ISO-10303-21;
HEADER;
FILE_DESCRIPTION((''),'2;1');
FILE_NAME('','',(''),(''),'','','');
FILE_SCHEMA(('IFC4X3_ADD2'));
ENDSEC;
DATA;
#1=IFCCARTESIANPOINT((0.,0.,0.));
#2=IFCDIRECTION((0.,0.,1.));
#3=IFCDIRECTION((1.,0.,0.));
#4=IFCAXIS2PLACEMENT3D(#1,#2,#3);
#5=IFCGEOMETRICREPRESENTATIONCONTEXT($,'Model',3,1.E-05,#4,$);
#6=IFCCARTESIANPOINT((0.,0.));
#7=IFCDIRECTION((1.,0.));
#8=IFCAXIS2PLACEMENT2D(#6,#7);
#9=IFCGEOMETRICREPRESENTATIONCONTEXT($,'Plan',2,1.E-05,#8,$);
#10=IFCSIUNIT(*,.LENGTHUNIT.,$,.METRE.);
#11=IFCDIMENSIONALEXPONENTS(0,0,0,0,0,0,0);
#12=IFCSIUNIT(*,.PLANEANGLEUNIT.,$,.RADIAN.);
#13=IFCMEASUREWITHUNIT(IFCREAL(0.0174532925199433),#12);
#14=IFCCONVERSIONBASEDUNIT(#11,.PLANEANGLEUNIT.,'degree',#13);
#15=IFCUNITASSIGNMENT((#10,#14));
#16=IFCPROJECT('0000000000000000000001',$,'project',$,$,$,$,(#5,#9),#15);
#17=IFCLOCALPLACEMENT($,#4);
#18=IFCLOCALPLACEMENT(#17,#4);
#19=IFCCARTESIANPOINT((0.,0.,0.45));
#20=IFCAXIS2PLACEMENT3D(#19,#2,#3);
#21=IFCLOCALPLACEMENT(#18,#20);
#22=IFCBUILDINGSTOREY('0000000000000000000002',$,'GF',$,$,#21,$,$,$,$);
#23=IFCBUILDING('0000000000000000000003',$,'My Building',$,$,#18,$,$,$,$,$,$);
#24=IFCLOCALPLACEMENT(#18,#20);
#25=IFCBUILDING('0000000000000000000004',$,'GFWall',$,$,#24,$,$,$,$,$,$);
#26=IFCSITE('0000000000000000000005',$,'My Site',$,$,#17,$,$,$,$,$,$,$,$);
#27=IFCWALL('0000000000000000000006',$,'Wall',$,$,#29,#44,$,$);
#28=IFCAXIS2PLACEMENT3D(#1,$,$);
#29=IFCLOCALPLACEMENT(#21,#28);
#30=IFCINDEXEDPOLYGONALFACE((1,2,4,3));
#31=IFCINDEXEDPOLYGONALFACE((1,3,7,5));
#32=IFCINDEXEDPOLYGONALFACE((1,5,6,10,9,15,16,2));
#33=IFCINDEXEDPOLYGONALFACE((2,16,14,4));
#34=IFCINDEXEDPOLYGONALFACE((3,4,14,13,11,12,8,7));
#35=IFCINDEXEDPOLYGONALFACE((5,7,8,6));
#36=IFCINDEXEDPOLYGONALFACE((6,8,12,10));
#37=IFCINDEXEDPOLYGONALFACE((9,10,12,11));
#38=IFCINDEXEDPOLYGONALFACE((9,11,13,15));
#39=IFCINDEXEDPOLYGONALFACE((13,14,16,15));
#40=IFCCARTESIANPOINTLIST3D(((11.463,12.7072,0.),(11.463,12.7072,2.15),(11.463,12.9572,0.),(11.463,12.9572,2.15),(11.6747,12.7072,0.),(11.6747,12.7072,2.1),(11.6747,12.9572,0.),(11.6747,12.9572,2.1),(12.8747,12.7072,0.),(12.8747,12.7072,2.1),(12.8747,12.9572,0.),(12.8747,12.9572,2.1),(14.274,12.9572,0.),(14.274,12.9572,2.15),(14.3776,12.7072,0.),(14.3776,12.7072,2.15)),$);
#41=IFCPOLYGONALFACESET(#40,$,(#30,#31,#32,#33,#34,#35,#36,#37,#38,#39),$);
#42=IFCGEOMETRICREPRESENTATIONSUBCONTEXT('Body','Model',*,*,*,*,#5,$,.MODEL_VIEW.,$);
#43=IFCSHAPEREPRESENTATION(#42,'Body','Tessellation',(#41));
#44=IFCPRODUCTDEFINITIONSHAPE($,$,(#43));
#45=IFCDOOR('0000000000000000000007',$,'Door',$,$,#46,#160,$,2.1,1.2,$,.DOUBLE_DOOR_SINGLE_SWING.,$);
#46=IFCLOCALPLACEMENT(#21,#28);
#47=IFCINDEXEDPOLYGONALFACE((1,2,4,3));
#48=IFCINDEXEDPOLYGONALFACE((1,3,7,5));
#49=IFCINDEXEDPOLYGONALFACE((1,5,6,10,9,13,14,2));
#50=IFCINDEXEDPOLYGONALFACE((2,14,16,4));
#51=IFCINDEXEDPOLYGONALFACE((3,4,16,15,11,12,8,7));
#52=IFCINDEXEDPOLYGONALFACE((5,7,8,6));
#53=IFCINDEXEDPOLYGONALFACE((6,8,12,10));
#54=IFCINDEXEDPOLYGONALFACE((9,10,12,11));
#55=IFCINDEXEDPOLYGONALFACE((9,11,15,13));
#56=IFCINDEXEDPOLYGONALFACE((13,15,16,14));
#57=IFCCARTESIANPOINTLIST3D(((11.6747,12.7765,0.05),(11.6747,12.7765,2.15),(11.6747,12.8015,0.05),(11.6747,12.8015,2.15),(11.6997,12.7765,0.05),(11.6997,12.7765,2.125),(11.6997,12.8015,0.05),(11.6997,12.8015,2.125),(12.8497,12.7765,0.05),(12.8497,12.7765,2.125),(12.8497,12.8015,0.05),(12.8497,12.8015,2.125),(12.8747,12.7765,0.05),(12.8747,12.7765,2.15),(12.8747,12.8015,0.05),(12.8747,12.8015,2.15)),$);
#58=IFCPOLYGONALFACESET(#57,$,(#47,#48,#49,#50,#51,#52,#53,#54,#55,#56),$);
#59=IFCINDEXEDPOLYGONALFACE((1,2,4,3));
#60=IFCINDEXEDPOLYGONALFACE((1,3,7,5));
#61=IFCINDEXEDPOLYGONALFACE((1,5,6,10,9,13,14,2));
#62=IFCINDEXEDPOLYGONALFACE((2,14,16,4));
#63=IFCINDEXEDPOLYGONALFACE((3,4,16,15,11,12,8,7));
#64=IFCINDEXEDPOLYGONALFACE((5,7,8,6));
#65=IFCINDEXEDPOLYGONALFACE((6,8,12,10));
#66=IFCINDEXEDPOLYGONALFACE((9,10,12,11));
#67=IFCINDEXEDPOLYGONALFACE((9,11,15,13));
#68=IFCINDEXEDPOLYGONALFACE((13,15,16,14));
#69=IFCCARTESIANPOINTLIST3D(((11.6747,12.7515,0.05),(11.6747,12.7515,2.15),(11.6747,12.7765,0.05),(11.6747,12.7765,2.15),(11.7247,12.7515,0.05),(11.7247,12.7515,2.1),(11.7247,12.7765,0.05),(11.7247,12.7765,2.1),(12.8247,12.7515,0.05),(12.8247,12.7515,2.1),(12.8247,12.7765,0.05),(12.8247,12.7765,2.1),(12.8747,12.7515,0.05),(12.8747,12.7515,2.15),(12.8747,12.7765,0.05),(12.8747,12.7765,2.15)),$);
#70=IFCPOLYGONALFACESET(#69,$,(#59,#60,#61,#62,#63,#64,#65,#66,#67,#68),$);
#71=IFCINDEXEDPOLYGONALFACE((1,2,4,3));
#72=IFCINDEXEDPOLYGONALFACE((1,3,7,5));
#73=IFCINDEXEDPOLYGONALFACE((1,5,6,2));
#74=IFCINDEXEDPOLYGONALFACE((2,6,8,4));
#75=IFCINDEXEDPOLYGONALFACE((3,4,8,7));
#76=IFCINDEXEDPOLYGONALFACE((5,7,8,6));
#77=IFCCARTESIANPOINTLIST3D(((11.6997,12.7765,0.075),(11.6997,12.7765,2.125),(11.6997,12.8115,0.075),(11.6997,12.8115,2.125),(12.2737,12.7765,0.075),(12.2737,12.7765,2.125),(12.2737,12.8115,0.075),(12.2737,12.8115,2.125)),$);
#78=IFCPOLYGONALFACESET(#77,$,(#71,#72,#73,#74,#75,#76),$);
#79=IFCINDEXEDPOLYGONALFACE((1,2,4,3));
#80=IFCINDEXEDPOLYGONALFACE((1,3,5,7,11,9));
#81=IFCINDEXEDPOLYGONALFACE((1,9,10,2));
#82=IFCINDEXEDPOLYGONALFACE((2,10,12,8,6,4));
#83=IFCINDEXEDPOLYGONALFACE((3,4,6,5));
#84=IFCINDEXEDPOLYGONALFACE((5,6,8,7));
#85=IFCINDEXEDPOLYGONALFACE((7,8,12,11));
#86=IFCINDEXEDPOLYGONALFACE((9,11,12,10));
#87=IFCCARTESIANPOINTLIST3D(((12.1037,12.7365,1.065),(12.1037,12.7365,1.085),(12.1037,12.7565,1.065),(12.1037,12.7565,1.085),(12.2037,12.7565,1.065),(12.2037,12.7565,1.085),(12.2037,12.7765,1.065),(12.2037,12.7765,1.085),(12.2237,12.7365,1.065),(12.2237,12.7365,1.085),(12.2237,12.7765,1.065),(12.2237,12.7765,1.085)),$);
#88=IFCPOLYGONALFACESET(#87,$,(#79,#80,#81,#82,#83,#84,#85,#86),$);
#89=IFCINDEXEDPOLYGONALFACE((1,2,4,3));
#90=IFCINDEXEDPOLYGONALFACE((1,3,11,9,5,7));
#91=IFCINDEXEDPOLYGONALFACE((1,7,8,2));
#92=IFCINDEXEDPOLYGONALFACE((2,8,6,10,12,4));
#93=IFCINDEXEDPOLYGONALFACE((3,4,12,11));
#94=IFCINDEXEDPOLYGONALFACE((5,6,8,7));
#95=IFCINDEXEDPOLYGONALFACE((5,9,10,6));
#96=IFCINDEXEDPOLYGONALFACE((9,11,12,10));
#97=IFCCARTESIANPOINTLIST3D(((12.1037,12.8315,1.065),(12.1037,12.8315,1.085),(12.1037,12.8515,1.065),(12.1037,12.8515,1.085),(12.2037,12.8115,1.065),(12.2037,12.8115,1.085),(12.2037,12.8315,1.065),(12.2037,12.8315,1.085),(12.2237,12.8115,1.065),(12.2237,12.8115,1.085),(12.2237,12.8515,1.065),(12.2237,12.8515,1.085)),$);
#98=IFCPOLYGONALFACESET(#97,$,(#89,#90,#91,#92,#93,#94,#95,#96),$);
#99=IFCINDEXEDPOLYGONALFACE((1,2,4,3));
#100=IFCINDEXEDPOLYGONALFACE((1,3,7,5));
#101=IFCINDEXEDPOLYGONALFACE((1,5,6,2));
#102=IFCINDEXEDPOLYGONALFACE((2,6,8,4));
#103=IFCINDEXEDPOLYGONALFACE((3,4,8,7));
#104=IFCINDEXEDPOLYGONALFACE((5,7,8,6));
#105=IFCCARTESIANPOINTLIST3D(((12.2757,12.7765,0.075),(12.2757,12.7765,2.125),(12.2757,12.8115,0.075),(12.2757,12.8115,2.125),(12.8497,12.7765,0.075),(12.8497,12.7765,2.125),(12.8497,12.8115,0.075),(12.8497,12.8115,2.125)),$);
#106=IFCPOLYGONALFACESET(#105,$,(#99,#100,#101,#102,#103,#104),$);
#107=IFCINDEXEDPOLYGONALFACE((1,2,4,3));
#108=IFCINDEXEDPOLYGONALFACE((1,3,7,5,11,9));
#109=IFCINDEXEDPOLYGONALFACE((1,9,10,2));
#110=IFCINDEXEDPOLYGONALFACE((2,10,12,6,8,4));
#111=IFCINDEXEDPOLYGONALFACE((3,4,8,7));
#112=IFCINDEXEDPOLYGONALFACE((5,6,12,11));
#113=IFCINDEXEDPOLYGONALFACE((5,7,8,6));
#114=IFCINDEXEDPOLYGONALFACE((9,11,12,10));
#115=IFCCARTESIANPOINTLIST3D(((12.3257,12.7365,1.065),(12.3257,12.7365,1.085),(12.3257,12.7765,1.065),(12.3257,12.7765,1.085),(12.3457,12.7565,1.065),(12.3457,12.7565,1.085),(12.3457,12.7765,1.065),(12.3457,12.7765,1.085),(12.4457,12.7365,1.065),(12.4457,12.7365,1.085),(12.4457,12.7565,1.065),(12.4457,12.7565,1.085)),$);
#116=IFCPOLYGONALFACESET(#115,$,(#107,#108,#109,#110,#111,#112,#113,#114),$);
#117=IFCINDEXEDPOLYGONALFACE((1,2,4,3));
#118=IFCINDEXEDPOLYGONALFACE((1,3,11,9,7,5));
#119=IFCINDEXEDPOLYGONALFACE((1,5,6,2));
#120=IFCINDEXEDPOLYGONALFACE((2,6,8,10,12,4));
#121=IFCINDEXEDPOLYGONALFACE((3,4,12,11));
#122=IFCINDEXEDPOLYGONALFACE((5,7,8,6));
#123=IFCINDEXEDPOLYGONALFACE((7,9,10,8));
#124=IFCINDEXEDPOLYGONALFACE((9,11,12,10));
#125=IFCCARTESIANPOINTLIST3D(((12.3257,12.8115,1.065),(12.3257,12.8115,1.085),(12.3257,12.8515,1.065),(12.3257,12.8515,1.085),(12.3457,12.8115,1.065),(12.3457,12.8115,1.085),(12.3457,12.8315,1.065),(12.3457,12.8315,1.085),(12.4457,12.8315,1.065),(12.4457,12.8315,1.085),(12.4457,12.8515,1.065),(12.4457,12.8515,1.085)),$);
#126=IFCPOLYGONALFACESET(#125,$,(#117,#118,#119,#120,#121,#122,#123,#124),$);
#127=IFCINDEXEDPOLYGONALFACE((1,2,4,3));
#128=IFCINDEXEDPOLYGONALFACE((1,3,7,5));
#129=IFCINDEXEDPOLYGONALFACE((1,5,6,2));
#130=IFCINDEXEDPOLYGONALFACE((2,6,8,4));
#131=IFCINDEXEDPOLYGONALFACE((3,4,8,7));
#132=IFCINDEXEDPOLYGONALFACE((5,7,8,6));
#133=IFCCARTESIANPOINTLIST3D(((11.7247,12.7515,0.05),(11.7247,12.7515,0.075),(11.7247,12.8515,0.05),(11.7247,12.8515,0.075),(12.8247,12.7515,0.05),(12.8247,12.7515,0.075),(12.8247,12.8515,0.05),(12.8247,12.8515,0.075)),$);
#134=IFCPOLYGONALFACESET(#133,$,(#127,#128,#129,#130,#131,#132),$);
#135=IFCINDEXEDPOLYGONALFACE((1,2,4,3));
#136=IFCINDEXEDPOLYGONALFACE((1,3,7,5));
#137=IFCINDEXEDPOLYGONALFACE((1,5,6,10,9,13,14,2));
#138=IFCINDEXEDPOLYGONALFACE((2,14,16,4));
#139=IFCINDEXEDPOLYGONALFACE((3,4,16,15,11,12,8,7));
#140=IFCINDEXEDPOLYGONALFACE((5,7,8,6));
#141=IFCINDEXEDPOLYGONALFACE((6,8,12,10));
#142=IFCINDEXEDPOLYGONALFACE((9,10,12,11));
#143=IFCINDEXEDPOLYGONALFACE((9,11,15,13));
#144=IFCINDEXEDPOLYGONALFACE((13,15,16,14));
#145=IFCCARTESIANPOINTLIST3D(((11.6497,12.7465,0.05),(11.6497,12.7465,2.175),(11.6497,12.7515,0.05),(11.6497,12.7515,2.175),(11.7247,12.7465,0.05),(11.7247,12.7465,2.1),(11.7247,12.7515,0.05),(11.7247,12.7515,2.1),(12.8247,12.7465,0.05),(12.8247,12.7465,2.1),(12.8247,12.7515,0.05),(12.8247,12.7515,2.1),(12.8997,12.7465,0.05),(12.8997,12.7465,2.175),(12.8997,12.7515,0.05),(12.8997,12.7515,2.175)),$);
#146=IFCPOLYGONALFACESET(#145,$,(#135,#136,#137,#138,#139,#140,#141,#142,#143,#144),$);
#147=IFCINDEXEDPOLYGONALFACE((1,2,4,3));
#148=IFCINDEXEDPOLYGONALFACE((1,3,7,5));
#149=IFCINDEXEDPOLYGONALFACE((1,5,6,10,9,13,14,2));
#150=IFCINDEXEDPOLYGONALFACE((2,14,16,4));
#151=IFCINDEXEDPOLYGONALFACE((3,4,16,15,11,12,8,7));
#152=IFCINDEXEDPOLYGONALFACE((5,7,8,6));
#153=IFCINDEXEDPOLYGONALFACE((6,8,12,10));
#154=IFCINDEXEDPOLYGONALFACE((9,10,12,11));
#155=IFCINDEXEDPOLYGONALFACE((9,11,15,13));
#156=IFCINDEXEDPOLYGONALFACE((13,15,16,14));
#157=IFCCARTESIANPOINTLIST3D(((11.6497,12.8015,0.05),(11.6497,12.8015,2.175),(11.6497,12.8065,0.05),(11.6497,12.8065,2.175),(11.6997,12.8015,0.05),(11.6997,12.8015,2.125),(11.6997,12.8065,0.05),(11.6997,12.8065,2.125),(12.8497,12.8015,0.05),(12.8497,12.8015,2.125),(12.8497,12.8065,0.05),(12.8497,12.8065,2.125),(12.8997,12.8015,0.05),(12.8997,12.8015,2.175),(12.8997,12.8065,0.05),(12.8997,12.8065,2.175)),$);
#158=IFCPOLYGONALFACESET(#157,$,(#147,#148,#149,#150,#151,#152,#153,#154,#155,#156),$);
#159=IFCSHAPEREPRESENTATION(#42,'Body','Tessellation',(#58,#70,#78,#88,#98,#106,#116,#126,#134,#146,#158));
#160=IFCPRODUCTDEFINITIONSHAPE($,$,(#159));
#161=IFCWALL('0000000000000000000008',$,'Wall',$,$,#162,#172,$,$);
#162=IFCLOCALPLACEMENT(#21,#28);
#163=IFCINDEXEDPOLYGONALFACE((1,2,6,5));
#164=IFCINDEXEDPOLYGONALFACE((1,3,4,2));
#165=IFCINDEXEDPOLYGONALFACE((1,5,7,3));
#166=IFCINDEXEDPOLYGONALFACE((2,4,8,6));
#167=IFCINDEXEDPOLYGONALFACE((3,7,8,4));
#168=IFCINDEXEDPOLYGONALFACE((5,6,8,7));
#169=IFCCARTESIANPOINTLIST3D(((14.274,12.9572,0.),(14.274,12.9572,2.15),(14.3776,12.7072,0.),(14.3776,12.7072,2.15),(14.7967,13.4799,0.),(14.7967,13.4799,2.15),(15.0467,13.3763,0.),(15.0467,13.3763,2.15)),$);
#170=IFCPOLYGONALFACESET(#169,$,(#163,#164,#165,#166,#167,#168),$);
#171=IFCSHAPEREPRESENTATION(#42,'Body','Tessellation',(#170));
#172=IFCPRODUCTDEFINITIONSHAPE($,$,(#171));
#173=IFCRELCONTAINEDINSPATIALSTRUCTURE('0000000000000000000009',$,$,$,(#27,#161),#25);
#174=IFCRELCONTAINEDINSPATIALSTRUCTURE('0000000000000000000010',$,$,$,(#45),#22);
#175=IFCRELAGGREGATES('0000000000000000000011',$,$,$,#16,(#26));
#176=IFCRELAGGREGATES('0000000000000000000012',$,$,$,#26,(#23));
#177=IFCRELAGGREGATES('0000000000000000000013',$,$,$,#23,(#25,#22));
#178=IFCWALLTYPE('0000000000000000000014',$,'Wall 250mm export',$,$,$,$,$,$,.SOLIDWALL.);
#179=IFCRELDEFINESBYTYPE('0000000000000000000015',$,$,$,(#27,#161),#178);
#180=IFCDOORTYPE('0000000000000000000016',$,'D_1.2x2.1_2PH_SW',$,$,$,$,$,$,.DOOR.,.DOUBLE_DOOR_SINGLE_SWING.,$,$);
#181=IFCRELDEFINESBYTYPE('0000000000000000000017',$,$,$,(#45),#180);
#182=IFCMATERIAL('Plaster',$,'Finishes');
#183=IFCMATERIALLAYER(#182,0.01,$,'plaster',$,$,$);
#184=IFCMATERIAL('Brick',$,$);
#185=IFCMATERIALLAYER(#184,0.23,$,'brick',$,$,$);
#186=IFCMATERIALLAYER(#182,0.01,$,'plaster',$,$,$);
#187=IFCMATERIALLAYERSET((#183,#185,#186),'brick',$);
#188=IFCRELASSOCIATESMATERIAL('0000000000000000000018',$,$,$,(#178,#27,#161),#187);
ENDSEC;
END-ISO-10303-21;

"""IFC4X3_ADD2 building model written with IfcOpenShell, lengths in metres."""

from ifc_helpers import new_model, entity, si_unit, converted_unit, frame, origin_with_axes, origin_2d_with_axis, place, context, subcontext, project, spatial, line, indexed_curve, outline, extrude, shape, source, transform, mapped, material, layer, layer_set, layer_usage, type_object, type_shapes, element, fill, save


model = new_model("IFC4X3_ADD2")

# Units and contexts
model_context = context("Model", 3, precision=1e-05, world=origin_with_axes())
plan_context = context("Plan", 2, precision=1e-05, world=origin_2d_with_axis())
body_context_1 = subcontext(model_context, "Body", "Model", "MODEL_VIEW")
body_context_2 = subcontext(plan_context, "Body", "Plan", "PLAN_VIEW")
ifc_project = project(units=[si_unit("LENGTHUNIT", "METRE"), converted_unit("PLANEANGLEUNIT", "degree", entity("IfcReal", 0.0174532925199433), si_unit("PLANEANGLEUNIT", "RADIAN"), dimensions=[0, 0, 0, 0, 0, 0, 0])], contexts=[model_context, plan_context])

# Site, buildings
site_placement = place(None, origin_with_axes())
site = spatial("IfcSite", under=ifc_project, at=site_placement, Name="My Site")
building_1_placement = place(site_placement, origin_with_axes())
building_1 = spatial("IfcBuilding", under=site, at=building_1_placement, Name="My Building")
building_2_placement = place(building_1_placement, frame((0.0, 0.0, 0.45), z_axis=(0.0, 0.0, 1.0), x_axis=(1.0, 0.0, 0.0)))
building_2 = spatial("IfcBuilding", under=building_1, at=building_2_placement, Name="GFWall")

# Shared definitions
ifc_material_1 = material(Name="Plaster", Category="Finishes")
ifc_layer_1 = layer(ifc_material_1, 0.01, Name="plaster")
ifc_material_2 = material(Name="Brick")
ifc_layer_2 = layer(ifc_material_2, 0.23, Name="brick")
ifc_layer_3 = layer(ifc_material_1, 0.01, Name="plaster")
ifc_layer_set = layer_set([ifc_layer_1, ifc_layer_2, ifc_layer_3], Name="brick")
wall_type = type_object("IfcWallType", Name="Wall 250mm export", PredefinedType="SOLIDWALL", material=ifc_layer_set)

# Shared definitions
storey_placement = place(building_1_placement, frame((0.0, 0.0, 0.45), z_axis=(0.0, 0.0, 1.0), x_axis=(1.0, 0.0, 0.0)))
storey = spatial("IfcBuildingStorey", under=building_1, at=storey_placement, Name="GF")

# Wall, opening, door
shared_shape_1 = source(origin_with_axes(), body_context_1, "Body", "SweptSolid", [
    extrude(outline(indexed_curve([(0.0, 0.0), (1.2, 0.0), (1.2, 2.1), (0.0, 2.1)], segments=[line(1, 2, 3, 4, 1)])), frame((0.0, -0.6, 0.0), z_axis=(0.0, -1.0, 0.0), x_axis=(1.0, 0.0, 0.0)), (0.0, 0.0, -1.0), 1.2),
])
door_type_1 = type_object("IfcDoorType", Name="D_1.2x2.1_2PH_SW", OperationType="DOUBLE_DOOR_SINGLE_SWING", PredefinedType="DOOR")
shared_shape_2 = source(origin_with_axes(), body_context_1, "Body", "SweptSolid", [
    extrude(outline(indexed_curve([(0.0, 0.0), (0.0, 2.1), (1.2, 2.1), (1.2, 0.0), (1.175, 0.0), (1.175, 2.075), (0.025, 2.075), (0.025, 0.0)], segments=[line(1, 2, 3, 4, 5, 6, 7, 8, 1)])), frame((0.0, 0.025, 0.0), z_axis=(0.0, -1.0, 0.0), x_axis=(1.0, 0.0, 0.0)), (0.0, 0.0, -1.0), 0.025),
    extrude(outline(indexed_curve([(0.0, 0.0), (0.0, 2.1), (1.2, 2.1), (1.2, 0.0), (1.15, 0.0), (1.15, 2.05), (0.05, 2.05), (0.05, 0.0)], segments=[line(1, 2, 3, 4, 5, 6, 7, 8, 1)])), frame((0.0, 0.0, 0.0), z_axis=(0.0, -1.0, 0.0), x_axis=(1.0, 0.0, 0.0)), (0.0, 0.0, -1.0), 0.025),
    extrude(outline(indexed_curve([(0.0, 0.0), (0.574, 0.0), (0.574, 0.035), (0.0, 0.035)], segments=[line(1, 2, 3, 4, 1)])), frame((0.025, 0.025, 0.025), z_axis=(0.0, 0.0, 1.0), x_axis=(1.0, 0.0, 0.0)), (0.0, 0.0, 1.0), 2.05),
    extrude(outline(indexed_curve([(0.0, 0.0), (0.0, -0.04), (-0.12, -0.04), (-0.12, -0.02), (-0.02, -0.02), (-0.02, 0.0)], segments=[line(1, 2, 3, 4, 5, 6, 1)])), frame((0.549, 0.025, 1.015), z_axis=(0.0, 0.0, 1.0), x_axis=(1.0, 0.0, 0.0)), (0.0, 0.0, 1.0), 0.02),
    extrude(outline(indexed_curve([(0.0, 0.0), (0.0, 0.04), (-0.12, 0.04), (-0.12, 0.02), (-0.02, 0.02), (-0.02, 0.0)], segments=[line(1, 2, 3, 4, 5, 6, 1)])), frame((0.549, 0.06, 1.015), z_axis=(0.0, 0.0, 1.0), x_axis=(1.0, 0.0, 0.0)), (0.0, 0.0, 1.0), 0.02),
    extrude(outline(indexed_curve([(0.0, 0.0), (-0.574, 0.0), (-0.574, 0.035), (0.0, 0.035)], segments=[line(1, 2, 3, 4, 1)])), frame((1.175, 0.025, 0.025), z_axis=(0.0, 0.0, 1.0), x_axis=(1.0, 0.0, 0.0)), (0.0, 0.0, 1.0), 2.05),
    extrude(outline(indexed_curve([(0.0, 0.0), (0.0, -0.04), (0.12, -0.04), (0.12, -0.02), (0.02, -0.02), (0.02, 0.0)], segments=[line(1, 2, 3, 4, 5, 6, 1)])), frame((0.651, 0.025, 1.015), z_axis=(0.0, 0.0, 1.0), x_axis=(1.0, 0.0, 0.0)), (0.0, 0.0, 1.0), 0.02),
    extrude(outline(indexed_curve([(0.0, 0.0), (0.0, 0.04), (0.12, 0.04), (0.12, 0.02), (0.02, 0.02), (0.02, 0.0)], segments=[line(1, 2, 3, 4, 5, 6, 1)])), frame((0.651, 0.06, 1.015), z_axis=(0.0, 0.0, 1.0), x_axis=(1.0, 0.0, 0.0)), (0.0, 0.0, 1.0), 0.02),
    extrude(outline(indexed_curve([(0.0, 0.0), (1.1, 0.0), (1.1, 0.1), (0.0, 0.1)], segments=[line(1, 2, 3, 4, 1)])), frame((0.05, 0.0, 0.0), z_axis=(0.0, 0.0, 1.0), x_axis=(1.0, 0.0, 0.0)), (0.0, 0.0, 1.0), 0.025),
    extrude(outline(indexed_curve([(0.0, 0.0), (0.0, 2.125), (1.25, 2.125), (1.25, 0.0), (1.175, 0.0), (1.175, 2.05), (0.075, 2.05), (0.075, 0.0)], segments=[line(1, 2, 3, 4, 5, 6, 7, 8, 1)])), frame((-0.025, -0.005, 0.0), z_axis=(0.0, -1.0, 0.0), x_axis=(1.0, 0.0, 0.0)), (0.0, 0.0, -1.0), 0.005),
    extrude(outline(indexed_curve([(0.0, 0.0), (0.0, 2.125), (1.25, 2.125), (1.25, 0.0), (1.2, 0.0), (1.2, 2.075), (0.05, 2.075), (0.05, 0.0)], segments=[line(1, 2, 3, 4, 5, 6, 7, 8, 1)])), frame((-0.025, 0.05, 0.0), z_axis=(0.0, -1.0, 0.0), x_axis=(1.0, 0.0, 0.0)), (0.0, 0.0, -1.0), 0.005),
])
shared_shape_3 = source(origin_with_axes(), body_context_2, "Body", "Curve2D", [
    entity("IfcIndexedPolyCurve", entity("IfcCartesianPointList2D", [[0.0, 0.0], [0.0, 0.05], [0.025, 0.05], [0.025, 0.025], [0.05, 0.025], [0.05, 0.0]]), [entity("IfcLineIndex", [1, 2, 3, 4, 5, 6, 1])]),
    entity("IfcIndexedPolyCurve", entity("IfcCartesianPointList2D", [[1.2, 0.0], [1.2, 0.05], [1.175, 0.05], [1.175, 0.025], [1.15, 0.025], [1.15, 0.0]]), [entity("IfcLineIndex", [1, 2, 3, 4, 5, 6, 1])]),
    entity("IfcTrimmedCurve", entity("IfcEllipse", entity("IfcAxis2Placement2D", entity("IfcCartesianPoint", [0.06, 0.05]), entity("IfcDirection", [1.0, 0.0])), 0.54, 0.575), [entity("IfcCartesianPoint", [0.6, 0.05])], [entity("IfcCartesianPoint", [0.06, 0.625])], True, "CARTESIAN"),
    entity("IfcIndexedPolyCurve", entity("IfcCartesianPointList2D", [[0.025, 0.05], [0.06, 0.05], [0.06, 0.625], [0.025, 0.625]]), [entity("IfcLineIndex", [1, 2, 3, 4, 1])]),
    entity("IfcTrimmedCurve", entity("IfcEllipse", entity("IfcAxis2Placement2D", entity("IfcCartesianPoint", [1.14, 0.05]), entity("IfcDirection", [1.0, 0.0])), 0.54, 0.575), [entity("IfcCartesianPoint", [1.14, 0.625])], [entity("IfcCartesianPoint", [0.6, 0.05])], True, "CARTESIAN"),
    entity("IfcIndexedPolyCurve", entity("IfcCartesianPointList2D", [[1.175, 0.05], [1.14, 0.05], [1.14, 0.625], [1.175, 0.625]]), [entity("IfcLineIndex", [1, 2, 3, 4, 1])]),
])
type_shapes(door_type_1, [shared_shape_2, shared_shape_3])
ifc_layer_usage_1 = layer_usage(ifc_layer_set, "AXIS2", "POSITIVE", 0.0)
wall_1_placement = place(building_2_placement, frame((11.463, 12.7072, 0.0), z_axis=(0.0, 0.0, 1.0), x_axis=(1.0, 0.0, 0.0)))
wall_1 = element("IfcWall", 1, at=wall_1_placement, inside=building_2, type_object=wall_type, material=ifc_layer_usage_1, Name="Wall", context=body_context_1, shape_type="SweptSolid", body=[
    extrude(outline(indexed_curve([(0.0, 0.0), (0.0, 0.25), (2.811, 0.25), (2.9146, 0.0)], segments=[line(1, 2, 3, 4, 1)])), origin_with_axes(), (0.0, 0.0, 1.0), 2.15),
])
opening_1_placement = place(wall_1_placement, frame((0.2117, 0.0443, 0.0), z_axis=(0.0, 0.0, 1.0), x_axis=(1.0, 0.0, 0.0)))
opening_1 = element("IfcOpeningElement", 2, at=opening_1_placement, cuts=wall_1, PredefinedType="OPENING", context=body_context_1, shape_type="MappedRepresentation", body=[
    mapped(shared_shape_1, transform((0.0, 0.0, 0.0), x_axis=(1.0, 0.0, 0.0), y_axis=(0.0, 1.0, 0.0), z_axis=(0.0, 0.0, 1.0), scale=1.0)),
])
door_1_placement = place(opening_1_placement, frame((0.0, 0.0, 0.05), z_axis=(0.0, 0.0, 1.0), x_axis=(1.0, 0.0, 0.0)))
door_1 = element("IfcDoor", 3, at=door_1_placement, inside=storey, type_object=door_type_1, Name="Door", OperationType="DOUBLE_DOOR_SINGLE_SWING", OverallHeight=2.1, OverallWidth=1.2, shapes=[
    shape(body_context_1, "Body", "MappedRepresentation", [mapped(shared_shape_2, transform((0.0, 0.0, 0.0), x_axis=(1.0, 0.0, 0.0), y_axis=(0.0, 1.0, 0.0), z_axis=(0.0, 0.0, 1.0), scale=1.0))]),
    shape(body_context_2, "Body", "MappedRepresentation", [mapped(shared_shape_3, transform((0.0, 0.0, 0.0), x_axis=(1.0, 0.0, 0.0), y_axis=(0.0, 1.0, 0.0), z_axis=(0.0, 0.0, 1.0), scale=1.0))]),
])
fill(opening_1, door_1)

# Wall
ifc_layer_usage_2 = layer_usage(ifc_layer_set, "AXIS2", "POSITIVE", 0.0)
wall_2_placement = place(building_2_placement, frame((14.3776, 12.7072, 0.0), z_axis=(0.0, 0.0, 1.0), x_axis=(0.707107, 0.707107, 0.0)))
element("IfcWall", 4, at=wall_2_placement, inside=building_2, type_object=wall_type, material=ifc_layer_usage_2, Name="Wall", context=body_context_1, shape_type="SweptSolid", body=[
    extrude(outline(indexed_curve([(0.0, 0.0), (0.1036, 0.25), (0.8427, 0.25), (0.9463, 0.0)], segments=[line(1, 2, 3, 4, 1)])), origin_with_axes(), (0.0, 0.0, 1.0), 2.15),
])

save(model, "model.ifc")
